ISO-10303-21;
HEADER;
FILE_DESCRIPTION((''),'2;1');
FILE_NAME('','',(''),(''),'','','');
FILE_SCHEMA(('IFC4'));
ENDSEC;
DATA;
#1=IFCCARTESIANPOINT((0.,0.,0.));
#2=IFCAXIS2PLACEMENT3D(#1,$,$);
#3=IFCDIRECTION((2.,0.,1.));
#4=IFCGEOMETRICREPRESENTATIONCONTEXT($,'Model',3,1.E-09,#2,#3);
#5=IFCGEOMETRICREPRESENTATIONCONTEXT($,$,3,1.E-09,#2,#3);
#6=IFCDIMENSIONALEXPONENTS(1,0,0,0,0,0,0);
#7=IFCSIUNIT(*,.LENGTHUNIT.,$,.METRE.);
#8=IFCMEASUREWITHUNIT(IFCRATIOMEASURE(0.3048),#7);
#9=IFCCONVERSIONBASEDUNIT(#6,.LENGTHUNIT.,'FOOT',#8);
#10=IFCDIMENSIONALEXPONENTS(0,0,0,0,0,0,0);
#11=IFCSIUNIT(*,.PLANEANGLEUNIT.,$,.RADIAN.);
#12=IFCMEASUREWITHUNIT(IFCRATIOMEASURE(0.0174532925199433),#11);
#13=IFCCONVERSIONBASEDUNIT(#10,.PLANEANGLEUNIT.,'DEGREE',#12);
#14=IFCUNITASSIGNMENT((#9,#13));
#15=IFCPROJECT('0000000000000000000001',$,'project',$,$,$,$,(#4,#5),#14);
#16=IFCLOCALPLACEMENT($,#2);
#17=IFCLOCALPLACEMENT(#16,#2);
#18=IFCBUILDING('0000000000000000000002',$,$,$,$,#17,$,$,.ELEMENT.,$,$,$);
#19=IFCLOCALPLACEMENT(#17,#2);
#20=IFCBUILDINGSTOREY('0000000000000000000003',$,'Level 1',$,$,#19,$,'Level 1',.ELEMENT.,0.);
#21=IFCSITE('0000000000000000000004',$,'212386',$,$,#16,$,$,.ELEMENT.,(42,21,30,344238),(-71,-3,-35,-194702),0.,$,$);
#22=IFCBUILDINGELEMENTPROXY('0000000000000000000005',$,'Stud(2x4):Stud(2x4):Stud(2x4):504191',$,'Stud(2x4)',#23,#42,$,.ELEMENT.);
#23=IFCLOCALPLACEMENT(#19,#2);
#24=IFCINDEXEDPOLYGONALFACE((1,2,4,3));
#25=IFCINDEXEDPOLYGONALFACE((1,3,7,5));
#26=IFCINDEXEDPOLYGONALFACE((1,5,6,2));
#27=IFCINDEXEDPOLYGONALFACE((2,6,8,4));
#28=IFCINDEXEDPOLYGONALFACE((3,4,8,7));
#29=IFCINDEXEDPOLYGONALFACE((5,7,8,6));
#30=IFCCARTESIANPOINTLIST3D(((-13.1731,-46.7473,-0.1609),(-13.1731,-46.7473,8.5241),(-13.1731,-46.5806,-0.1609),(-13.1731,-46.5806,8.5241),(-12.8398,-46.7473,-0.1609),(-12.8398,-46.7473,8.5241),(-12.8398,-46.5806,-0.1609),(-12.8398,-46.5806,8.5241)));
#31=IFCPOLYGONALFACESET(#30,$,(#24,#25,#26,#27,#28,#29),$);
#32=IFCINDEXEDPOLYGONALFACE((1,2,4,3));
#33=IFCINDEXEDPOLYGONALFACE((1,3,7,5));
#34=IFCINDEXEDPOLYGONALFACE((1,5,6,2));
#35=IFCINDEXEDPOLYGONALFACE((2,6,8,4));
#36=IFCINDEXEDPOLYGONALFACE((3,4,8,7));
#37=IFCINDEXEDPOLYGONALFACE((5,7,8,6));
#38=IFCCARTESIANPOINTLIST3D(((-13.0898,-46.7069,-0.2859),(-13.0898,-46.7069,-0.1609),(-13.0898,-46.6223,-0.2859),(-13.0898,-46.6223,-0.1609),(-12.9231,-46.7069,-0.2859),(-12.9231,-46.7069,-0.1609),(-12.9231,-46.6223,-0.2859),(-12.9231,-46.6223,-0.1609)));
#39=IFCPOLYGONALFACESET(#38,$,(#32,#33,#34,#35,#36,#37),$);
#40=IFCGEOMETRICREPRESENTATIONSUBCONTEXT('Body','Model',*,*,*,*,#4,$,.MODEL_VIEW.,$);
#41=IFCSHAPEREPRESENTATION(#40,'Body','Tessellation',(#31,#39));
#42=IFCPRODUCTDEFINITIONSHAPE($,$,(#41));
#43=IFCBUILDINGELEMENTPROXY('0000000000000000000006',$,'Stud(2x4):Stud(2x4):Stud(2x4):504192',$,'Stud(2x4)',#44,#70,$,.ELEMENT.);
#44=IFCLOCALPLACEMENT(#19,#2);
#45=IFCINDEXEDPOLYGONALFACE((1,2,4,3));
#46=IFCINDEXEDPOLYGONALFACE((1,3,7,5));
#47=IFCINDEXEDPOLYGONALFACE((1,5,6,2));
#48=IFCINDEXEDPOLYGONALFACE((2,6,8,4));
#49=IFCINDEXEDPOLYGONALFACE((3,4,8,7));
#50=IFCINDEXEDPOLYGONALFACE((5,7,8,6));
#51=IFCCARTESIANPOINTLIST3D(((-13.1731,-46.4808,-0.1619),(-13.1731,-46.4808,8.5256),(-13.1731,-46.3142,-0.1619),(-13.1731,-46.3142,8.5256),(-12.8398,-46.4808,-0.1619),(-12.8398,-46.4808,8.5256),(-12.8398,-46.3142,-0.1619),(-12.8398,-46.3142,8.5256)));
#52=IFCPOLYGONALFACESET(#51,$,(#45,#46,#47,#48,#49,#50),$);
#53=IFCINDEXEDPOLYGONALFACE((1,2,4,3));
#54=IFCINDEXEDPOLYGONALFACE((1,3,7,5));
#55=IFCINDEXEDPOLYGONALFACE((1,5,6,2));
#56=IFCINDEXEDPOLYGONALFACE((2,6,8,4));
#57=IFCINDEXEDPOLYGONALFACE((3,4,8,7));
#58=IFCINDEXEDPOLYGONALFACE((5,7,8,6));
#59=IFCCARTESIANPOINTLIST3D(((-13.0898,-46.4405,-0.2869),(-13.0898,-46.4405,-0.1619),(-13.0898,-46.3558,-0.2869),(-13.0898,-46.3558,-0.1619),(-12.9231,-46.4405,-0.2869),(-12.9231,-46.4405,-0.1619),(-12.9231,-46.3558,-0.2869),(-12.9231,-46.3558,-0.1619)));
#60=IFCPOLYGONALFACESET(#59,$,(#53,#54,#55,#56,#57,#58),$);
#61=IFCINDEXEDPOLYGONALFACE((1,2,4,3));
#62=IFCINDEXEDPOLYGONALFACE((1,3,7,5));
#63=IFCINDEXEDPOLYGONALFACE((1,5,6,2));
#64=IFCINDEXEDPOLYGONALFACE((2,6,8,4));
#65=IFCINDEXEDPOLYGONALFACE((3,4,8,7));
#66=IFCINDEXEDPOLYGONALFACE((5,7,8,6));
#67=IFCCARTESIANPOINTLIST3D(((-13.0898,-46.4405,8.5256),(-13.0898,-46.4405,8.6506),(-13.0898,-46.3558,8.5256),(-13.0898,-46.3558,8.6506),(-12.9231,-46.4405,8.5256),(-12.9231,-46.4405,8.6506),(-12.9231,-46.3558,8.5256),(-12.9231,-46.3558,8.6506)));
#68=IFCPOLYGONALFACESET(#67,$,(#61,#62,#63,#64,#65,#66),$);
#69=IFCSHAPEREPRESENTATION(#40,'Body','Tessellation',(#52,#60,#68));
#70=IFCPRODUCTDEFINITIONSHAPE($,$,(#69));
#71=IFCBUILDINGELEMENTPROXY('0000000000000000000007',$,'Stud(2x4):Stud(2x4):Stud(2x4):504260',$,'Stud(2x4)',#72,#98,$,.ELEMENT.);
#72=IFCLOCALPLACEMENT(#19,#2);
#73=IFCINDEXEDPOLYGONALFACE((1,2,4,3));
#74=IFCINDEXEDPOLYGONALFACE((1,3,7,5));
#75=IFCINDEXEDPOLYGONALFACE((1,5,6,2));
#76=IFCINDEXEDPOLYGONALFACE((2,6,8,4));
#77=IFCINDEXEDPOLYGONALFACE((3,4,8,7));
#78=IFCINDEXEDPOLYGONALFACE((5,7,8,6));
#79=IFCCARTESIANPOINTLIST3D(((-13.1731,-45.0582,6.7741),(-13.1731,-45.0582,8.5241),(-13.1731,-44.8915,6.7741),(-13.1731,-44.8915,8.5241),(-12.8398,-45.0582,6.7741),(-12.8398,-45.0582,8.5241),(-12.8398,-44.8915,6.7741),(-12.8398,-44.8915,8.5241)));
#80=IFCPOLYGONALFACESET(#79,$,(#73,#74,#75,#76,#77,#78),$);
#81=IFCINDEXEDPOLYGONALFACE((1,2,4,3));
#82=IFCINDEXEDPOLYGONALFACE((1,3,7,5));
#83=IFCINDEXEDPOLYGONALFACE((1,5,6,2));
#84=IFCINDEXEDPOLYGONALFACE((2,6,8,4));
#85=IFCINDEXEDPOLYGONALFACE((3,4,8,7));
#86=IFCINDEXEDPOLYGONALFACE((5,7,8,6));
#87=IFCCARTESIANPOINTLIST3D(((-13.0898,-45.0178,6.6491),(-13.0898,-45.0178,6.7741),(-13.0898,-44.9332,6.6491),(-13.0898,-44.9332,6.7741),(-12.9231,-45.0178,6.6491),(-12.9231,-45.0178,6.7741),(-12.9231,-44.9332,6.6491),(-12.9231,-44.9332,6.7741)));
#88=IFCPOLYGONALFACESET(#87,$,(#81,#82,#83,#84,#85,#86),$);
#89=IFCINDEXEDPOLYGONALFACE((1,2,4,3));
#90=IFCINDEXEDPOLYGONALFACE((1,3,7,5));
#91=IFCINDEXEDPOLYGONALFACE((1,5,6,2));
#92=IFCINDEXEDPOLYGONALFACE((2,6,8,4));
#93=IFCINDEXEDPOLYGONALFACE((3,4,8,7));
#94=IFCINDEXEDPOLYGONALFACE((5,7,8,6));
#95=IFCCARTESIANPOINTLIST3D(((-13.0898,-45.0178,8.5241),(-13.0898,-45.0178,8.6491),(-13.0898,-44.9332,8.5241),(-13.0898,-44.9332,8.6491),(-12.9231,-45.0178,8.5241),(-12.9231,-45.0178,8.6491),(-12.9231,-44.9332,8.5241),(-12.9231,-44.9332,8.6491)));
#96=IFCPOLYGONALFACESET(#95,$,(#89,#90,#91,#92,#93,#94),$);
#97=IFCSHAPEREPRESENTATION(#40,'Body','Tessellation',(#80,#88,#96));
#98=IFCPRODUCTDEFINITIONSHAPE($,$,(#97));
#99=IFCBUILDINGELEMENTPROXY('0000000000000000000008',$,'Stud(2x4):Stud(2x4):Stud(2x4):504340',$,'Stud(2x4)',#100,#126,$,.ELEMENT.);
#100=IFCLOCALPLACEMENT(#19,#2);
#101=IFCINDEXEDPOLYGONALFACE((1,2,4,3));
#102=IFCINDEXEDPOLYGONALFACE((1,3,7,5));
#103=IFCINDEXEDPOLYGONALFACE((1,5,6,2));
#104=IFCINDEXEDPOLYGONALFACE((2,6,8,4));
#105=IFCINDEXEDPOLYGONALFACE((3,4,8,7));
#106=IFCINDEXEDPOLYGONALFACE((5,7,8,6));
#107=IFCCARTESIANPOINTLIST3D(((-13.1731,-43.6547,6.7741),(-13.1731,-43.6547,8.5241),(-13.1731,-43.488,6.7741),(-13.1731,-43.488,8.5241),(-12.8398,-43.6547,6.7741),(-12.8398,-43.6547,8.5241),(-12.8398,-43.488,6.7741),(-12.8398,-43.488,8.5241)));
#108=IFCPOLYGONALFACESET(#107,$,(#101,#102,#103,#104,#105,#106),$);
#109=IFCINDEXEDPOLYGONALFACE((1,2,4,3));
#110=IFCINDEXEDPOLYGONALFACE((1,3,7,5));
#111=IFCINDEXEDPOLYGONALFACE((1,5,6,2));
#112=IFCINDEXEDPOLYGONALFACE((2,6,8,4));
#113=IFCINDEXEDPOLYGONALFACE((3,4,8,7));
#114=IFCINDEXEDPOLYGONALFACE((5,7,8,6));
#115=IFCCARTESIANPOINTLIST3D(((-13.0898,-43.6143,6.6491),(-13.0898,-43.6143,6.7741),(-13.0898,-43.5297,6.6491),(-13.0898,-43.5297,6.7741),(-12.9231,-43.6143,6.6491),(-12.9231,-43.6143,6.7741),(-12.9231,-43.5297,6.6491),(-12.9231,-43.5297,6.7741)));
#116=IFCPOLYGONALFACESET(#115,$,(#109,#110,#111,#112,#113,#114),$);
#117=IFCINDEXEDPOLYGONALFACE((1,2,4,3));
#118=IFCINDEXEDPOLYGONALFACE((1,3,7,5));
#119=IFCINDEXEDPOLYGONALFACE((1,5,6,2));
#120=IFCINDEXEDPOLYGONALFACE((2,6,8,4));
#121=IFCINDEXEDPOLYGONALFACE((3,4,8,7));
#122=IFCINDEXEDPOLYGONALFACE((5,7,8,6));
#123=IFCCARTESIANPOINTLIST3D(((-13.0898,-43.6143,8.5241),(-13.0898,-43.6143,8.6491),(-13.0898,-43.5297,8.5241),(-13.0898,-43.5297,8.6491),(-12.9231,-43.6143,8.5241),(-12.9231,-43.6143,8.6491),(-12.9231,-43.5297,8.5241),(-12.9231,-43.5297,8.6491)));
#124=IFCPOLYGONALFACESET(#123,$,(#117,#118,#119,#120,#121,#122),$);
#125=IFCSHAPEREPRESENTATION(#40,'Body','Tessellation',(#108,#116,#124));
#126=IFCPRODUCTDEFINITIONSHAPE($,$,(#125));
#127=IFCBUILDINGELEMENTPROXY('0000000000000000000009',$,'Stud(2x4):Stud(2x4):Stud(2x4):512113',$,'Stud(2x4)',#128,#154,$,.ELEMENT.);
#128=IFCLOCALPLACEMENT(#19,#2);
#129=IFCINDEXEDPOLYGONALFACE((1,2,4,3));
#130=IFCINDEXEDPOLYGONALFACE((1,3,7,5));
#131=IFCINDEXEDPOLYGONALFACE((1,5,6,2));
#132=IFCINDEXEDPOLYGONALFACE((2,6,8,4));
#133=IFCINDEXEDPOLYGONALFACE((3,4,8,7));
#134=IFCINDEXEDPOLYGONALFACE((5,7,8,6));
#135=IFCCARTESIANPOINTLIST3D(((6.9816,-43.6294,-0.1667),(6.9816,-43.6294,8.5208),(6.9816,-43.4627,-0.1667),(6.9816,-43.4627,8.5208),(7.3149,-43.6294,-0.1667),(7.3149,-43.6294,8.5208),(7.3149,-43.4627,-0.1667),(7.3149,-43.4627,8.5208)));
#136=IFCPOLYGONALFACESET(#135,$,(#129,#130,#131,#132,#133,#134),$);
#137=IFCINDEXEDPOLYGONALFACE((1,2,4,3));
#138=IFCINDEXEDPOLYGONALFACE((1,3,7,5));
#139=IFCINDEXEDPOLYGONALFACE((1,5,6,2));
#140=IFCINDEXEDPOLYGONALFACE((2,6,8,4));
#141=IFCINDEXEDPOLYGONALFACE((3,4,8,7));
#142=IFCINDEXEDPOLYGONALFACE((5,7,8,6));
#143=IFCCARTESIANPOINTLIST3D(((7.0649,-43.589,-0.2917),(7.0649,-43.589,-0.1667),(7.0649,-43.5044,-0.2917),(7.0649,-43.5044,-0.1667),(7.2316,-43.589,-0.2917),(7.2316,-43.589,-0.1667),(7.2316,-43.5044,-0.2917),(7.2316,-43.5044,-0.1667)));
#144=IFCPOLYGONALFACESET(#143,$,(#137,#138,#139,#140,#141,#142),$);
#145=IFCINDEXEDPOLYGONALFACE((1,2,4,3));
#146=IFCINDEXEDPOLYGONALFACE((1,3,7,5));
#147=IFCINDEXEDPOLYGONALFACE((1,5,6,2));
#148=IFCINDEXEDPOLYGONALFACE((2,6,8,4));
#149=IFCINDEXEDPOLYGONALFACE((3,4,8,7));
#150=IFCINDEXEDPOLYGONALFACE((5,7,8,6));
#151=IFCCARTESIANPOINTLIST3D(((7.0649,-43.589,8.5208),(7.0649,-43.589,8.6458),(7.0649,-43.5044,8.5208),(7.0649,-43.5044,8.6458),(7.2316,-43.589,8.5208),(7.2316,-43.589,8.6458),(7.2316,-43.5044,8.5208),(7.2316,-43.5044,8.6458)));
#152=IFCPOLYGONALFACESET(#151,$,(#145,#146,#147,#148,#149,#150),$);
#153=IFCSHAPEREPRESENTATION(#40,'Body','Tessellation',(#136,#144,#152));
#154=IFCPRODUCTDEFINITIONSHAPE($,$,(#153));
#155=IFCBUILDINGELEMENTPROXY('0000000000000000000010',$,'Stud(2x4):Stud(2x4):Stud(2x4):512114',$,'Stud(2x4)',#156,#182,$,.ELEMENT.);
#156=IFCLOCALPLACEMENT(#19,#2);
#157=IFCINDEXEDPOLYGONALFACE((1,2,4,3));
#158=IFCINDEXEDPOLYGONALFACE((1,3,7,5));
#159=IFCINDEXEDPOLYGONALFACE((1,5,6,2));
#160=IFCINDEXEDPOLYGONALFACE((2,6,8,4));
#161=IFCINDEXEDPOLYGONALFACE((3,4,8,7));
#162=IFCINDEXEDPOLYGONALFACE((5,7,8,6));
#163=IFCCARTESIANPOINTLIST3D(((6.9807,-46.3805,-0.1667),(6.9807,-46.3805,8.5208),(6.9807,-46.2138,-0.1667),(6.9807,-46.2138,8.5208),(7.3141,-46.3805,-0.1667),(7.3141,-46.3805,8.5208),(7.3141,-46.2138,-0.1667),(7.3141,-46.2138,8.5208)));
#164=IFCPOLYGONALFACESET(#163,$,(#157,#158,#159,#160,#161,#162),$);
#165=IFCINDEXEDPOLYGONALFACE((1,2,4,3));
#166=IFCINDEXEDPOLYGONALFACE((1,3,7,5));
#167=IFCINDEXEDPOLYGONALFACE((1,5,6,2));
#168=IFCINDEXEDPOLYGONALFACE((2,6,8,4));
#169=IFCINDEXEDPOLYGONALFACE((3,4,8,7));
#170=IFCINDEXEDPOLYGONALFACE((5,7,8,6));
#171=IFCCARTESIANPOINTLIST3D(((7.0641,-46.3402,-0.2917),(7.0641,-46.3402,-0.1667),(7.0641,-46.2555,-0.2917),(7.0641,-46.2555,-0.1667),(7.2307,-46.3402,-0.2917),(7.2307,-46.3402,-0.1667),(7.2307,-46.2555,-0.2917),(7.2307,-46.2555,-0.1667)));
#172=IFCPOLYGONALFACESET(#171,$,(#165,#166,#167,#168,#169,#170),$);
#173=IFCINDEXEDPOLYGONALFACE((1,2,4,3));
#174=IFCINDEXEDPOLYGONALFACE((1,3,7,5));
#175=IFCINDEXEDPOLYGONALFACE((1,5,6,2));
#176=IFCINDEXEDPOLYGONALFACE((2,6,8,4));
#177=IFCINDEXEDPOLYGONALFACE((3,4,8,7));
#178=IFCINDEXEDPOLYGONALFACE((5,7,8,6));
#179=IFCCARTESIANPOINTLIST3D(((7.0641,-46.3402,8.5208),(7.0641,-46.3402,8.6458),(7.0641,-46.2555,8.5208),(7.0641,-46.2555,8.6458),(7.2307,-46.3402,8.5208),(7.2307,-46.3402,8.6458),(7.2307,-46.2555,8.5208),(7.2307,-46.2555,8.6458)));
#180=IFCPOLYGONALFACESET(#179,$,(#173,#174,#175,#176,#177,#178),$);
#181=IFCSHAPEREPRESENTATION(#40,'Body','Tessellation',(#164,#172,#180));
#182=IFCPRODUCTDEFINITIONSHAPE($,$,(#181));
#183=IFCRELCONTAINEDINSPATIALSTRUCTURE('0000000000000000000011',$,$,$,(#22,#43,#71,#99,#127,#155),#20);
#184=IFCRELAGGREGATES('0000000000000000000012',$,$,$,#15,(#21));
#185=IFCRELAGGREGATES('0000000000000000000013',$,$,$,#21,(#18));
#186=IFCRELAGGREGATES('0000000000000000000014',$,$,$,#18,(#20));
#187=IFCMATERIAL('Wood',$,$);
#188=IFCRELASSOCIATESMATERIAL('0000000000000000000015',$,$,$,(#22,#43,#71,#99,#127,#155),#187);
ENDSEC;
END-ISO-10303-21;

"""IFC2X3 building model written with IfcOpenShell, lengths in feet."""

from ifc_helpers import new_model, entity, si_unit, converted_unit, direction, frame, frame_2d, origin, place, context, subcontext, project, spatial, rectangle, extrude, source, transform, mapped, material, element, save


model = new_model("IFC2X3")

# Units and contexts
model_context = context("Model", 3, precision=1e-09, world=origin(), true_north=direction((2.0, 0.0, 1.0)))
context_of_model = context(None, 3, precision=1e-09, world=origin(), true_north=direction((2.0, 0.0, 1.0)))
body_context = subcontext(model_context, "Body", "Model", "MODEL_VIEW")
ifc_project = project(units=[converted_unit("LENGTHUNIT", "FOOT", entity("IfcRatioMeasure", 0.3048), si_unit("LENGTHUNIT", "METRE"), dimensions=[1, 0, 0, 0, 0, 0, 0]), converted_unit("PLANEANGLEUNIT", "DEGREE", entity("IfcRatioMeasure", 0.0174532925199433), si_unit("PLANEANGLEUNIT", "RADIAN"), dimensions=[0, 0, 0, 0, 0, 0, 0])], contexts=[model_context, context_of_model])

# Site, building, storey
site_placement = place(None, origin())
site = spatial("IfcSite", under=ifc_project, at=site_placement, Name="212386", CompositionType="ELEMENT", RefLatitude=(42, 21, 30, 344238), RefLongitude=(-71, -3, -35, -194702), RefElevation=0.0)
building_placement = place(site_placement, origin())
building = spatial("IfcBuilding", under=site, at=building_placement, CompositionType="ELEMENT")
storey_placement = place(building_placement, origin())
storey = spatial("IfcBuildingStorey", under=building, at=storey_placement, Name="Level 1", LongName="Level 1", CompositionType="ELEMENT", Elevation=0.0)

# Building element proxies
ifc_material = material(Name="Wood")
shared_shape_1 = source(origin(), body_context, "Body", "SweptSolid", [
    extrude(rectangle(XDim=0.3333, YDim=0.1667, at=frame_2d((0.0, 0.0), x_axis=(1.0, 0.0))), frame((-13.0064, -46.6639, -0.1609), z_axis=(0.0, 0.0, 1.0), x_axis=(-1.0, 0.0, 0.0)), (0.0, 0.0, 1.0), 8.685),
    extrude(rectangle(XDim=0.1667, YDim=0.0847, at=frame_2d((0.0, 0.0), x_axis=(1.0, 0.0))), frame((-13.0064, -46.6646, -0.2859), z_axis=(0.0, 0.0, 1.0), x_axis=(-1.0, 0.0, 0.0)), (0.0, 0.0, 1.0), 0.125),
])
proxy_1_placement = place(storey_placement, origin())
element("IfcBuildingElementProxy", 1, at=proxy_1_placement, inside=storey, material=ifc_material, Name="Stud(2x4):Stud(2x4):Stud(2x4):504191", ObjectType="Stud(2x4)", CompositionType="ELEMENT", context=body_context, shape_type="MappedRepresentation", body=[
    mapped(shared_shape_1, transform((0.0, 0.0, 0.0), scale=1.0)),
])
shared_shape_2 = source(origin(), body_context, "Body", "SweptSolid", [
    extrude(rectangle(XDim=0.3333, YDim=0.1667, at=frame_2d((0.0, 0.0), x_axis=(1.0, 0.0))), frame((-13.0064, -46.3975, -0.1619), z_axis=(0.0, 0.0, 1.0), x_axis=(-1.0, 0.0, 0.0)), (0.0, 0.0, 1.0), 8.6875),
    extrude(rectangle(XDim=0.1667, YDim=0.0847, at=frame_2d((0.0, 0.0), x_axis=(1.0, 0.0))), frame((-13.0064, -46.3982, -0.2869), z_axis=(0.0, 0.0, 1.0), x_axis=(-1.0, 0.0, 0.0)), (0.0, 0.0, 1.0), 0.125),
    extrude(rectangle(XDim=0.0847, YDim=0.1667, at=frame_2d((0.0, 0.0), x_axis=(1.0, 0.0))), frame((-13.0064, -46.3982, 8.5256), z_axis=(0.0, 0.0, 1.0), x_axis=(0.0, -1.0, 0.0)), (0.0, 0.0, 1.0), 0.125),
])
proxy_2_placement = place(storey_placement, origin())
element("IfcBuildingElementProxy", 2, at=proxy_2_placement, inside=storey, material=ifc_material, Name="Stud(2x4):Stud(2x4):Stud(2x4):504192", ObjectType="Stud(2x4)", CompositionType="ELEMENT", context=body_context, shape_type="MappedRepresentation", body=[
    mapped(shared_shape_2, transform((0.0, 0.0, 0.0), scale=1.0)),
])
shared_shape_3 = source(origin(), body_context, "Body", "SweptSolid", [
    extrude(rectangle(XDim=0.3333, YDim=0.1667, at=frame_2d((0.0, 0.0), x_axis=(1.0, 0.0))), frame((-13.0064, -44.9748, 6.7741), z_axis=(0.0, 0.0, 1.0), x_axis=(-1.0, 0.0, 0.0)), (0.0, 0.0, 1.0), 1.75),
    extrude(rectangle(XDim=0.1667, YDim=0.0847, at=frame_2d((0.0, 0.0), x_axis=(1.0, 0.0))), frame((-13.0064, -44.9755, 6.6491), z_axis=(0.0, 0.0, 1.0), x_axis=(-1.0, 0.0, 0.0)), (0.0, 0.0, 1.0), 0.125),
    extrude(rectangle(XDim=0.0847, YDim=0.1667, at=frame_2d((0.0, 0.0), x_axis=(1.0, 0.0))), frame((-13.0064, -44.9755, 8.5241), z_axis=(0.0, 0.0, 1.0), x_axis=(0.0, -1.0, 0.0)), (0.0, 0.0, 1.0), 0.125),
])
proxy_3_placement = place(storey_placement, origin())
element("IfcBuildingElementProxy", 3, at=proxy_3_placement, inside=storey, material=ifc_material, Name="Stud(2x4):Stud(2x4):Stud(2x4):504260", ObjectType="Stud(2x4)", CompositionType="ELEMENT", context=body_context, shape_type="MappedRepresentation", body=[
    mapped(shared_shape_3, transform((0.0, 0.0, 0.0), scale=1.0)),
])
shared_shape_4 = source(origin(), body_context, "Body", "SweptSolid", [
    extrude(rectangle(XDim=0.3333, YDim=0.1667, at=frame_2d((0.0, 0.0), x_axis=(1.0, 0.0))), frame((-13.0064, -43.5713, 6.7741), z_axis=(0.0, 0.0, 1.0), x_axis=(-1.0, 0.0, 0.0)), (0.0, 0.0, 1.0), 1.75),
    extrude(rectangle(XDim=0.1667, YDim=0.0847, at=frame_2d((0.0, 0.0), x_axis=(1.0, 0.0))), frame((-13.0064, -43.572, 6.6491), z_axis=(0.0, 0.0, 1.0), x_axis=(-1.0, 0.0, 0.0)), (0.0, 0.0, 1.0), 0.125),
    extrude(rectangle(XDim=0.0847, YDim=0.1667, at=frame_2d((0.0, 0.0), x_axis=(1.0, 0.0))), frame((-13.0064, -43.572, 8.5241), z_axis=(0.0, 0.0, 1.0), x_axis=(0.0, -1.0, 0.0)), (0.0, 0.0, 1.0), 0.125),
])
proxy_4_placement = place(storey_placement, origin())
element("IfcBuildingElementProxy", 4, at=proxy_4_placement, inside=storey, material=ifc_material, Name="Stud(2x4):Stud(2x4):Stud(2x4):504340", ObjectType="Stud(2x4)", CompositionType="ELEMENT", context=body_context, shape_type="MappedRepresentation", body=[
    mapped(shared_shape_4, transform((0.0, 0.0, 0.0), scale=1.0)),
])
shared_shape_5 = source(origin(), body_context, "Body", "SweptSolid", [
    extrude(rectangle(XDim=0.1667, YDim=0.3333, at=frame_2d((0.0, 0.0), x_axis=(1.0, 0.0))), frame((7.1482, -43.546, -0.1667), z_axis=(0.0, 0.0, 1.0), x_axis=(0.0, -1.0, 0.0)), (0.0, 0.0, 1.0), 8.6875),
    extrude(rectangle(XDim=0.0847, YDim=0.1667, at=frame_2d((0.0, 0.0), x_axis=(1.0, 0.0))), frame((7.1482, -43.5467, -0.2917), z_axis=(0.0, 0.0, 1.0), x_axis=(0.0, -1.0, 0.0)), (0.0, 0.0, 1.0), 0.125),
    extrude(rectangle(XDim=0.1667, YDim=0.0847, at=frame_2d((0.0, 0.0), x_axis=(1.0, 0.0))), frame((7.1482, -43.5467, 8.5208), z_axis=(0.0, 0.0, 1.0), x_axis=(-1.0, 0.0, 0.0)), (0.0, 0.0, 1.0), 0.125),
])
proxy_5_placement = place(storey_placement, origin())
element("IfcBuildingElementProxy", 5, at=proxy_5_placement, inside=storey, material=ifc_material, Name="Stud(2x4):Stud(2x4):Stud(2x4):512113", ObjectType="Stud(2x4)", CompositionType="ELEMENT", context=body_context, shape_type="MappedRepresentation", body=[
    mapped(shared_shape_5, transform((0.0, 0.0, 0.0), scale=1.0)),
])
shared_shape_6 = source(origin(), body_context, "Body", "SweptSolid", [
    extrude(rectangle(XDim=0.1667, YDim=0.3333, at=frame_2d((0.0, 0.0), x_axis=(1.0, 0.0))), frame((7.1474, -46.2972, -0.1667), z_axis=(0.0, 0.0, 1.0), x_axis=(0.0, -1.0, 0.0)), (0.0, 0.0, 1.0), 8.6875),
    extrude(rectangle(XDim=0.0847, YDim=0.1667, at=frame_2d((0.0, 0.0), x_axis=(1.0, 0.0))), frame((7.1474, -46.2978, -0.2917), z_axis=(0.0, 0.0, 1.0), x_axis=(0.0, -1.0, 0.0)), (0.0, 0.0, 1.0), 0.125),
    extrude(rectangle(XDim=0.1667, YDim=0.0847, at=frame_2d((0.0, 0.0), x_axis=(1.0, 0.0))), frame((7.1474, -46.2978, 8.5208), z_axis=(0.0, 0.0, 1.0), x_axis=(-1.0, 0.0, 0.0)), (0.0, 0.0, 1.0), 0.125),
])
proxy_6_placement = place(storey_placement, origin())
element("IfcBuildingElementProxy", 6, at=proxy_6_placement, inside=storey, material=ifc_material, Name="Stud(2x4):Stud(2x4):Stud(2x4):512114", ObjectType="Stud(2x4)", CompositionType="ELEMENT", context=body_context, shape_type="MappedRepresentation", body=[
    mapped(shared_shape_6, transform((0.0, 0.0, 0.0), scale=1.0)),
])

save(model, "model.ifc")
